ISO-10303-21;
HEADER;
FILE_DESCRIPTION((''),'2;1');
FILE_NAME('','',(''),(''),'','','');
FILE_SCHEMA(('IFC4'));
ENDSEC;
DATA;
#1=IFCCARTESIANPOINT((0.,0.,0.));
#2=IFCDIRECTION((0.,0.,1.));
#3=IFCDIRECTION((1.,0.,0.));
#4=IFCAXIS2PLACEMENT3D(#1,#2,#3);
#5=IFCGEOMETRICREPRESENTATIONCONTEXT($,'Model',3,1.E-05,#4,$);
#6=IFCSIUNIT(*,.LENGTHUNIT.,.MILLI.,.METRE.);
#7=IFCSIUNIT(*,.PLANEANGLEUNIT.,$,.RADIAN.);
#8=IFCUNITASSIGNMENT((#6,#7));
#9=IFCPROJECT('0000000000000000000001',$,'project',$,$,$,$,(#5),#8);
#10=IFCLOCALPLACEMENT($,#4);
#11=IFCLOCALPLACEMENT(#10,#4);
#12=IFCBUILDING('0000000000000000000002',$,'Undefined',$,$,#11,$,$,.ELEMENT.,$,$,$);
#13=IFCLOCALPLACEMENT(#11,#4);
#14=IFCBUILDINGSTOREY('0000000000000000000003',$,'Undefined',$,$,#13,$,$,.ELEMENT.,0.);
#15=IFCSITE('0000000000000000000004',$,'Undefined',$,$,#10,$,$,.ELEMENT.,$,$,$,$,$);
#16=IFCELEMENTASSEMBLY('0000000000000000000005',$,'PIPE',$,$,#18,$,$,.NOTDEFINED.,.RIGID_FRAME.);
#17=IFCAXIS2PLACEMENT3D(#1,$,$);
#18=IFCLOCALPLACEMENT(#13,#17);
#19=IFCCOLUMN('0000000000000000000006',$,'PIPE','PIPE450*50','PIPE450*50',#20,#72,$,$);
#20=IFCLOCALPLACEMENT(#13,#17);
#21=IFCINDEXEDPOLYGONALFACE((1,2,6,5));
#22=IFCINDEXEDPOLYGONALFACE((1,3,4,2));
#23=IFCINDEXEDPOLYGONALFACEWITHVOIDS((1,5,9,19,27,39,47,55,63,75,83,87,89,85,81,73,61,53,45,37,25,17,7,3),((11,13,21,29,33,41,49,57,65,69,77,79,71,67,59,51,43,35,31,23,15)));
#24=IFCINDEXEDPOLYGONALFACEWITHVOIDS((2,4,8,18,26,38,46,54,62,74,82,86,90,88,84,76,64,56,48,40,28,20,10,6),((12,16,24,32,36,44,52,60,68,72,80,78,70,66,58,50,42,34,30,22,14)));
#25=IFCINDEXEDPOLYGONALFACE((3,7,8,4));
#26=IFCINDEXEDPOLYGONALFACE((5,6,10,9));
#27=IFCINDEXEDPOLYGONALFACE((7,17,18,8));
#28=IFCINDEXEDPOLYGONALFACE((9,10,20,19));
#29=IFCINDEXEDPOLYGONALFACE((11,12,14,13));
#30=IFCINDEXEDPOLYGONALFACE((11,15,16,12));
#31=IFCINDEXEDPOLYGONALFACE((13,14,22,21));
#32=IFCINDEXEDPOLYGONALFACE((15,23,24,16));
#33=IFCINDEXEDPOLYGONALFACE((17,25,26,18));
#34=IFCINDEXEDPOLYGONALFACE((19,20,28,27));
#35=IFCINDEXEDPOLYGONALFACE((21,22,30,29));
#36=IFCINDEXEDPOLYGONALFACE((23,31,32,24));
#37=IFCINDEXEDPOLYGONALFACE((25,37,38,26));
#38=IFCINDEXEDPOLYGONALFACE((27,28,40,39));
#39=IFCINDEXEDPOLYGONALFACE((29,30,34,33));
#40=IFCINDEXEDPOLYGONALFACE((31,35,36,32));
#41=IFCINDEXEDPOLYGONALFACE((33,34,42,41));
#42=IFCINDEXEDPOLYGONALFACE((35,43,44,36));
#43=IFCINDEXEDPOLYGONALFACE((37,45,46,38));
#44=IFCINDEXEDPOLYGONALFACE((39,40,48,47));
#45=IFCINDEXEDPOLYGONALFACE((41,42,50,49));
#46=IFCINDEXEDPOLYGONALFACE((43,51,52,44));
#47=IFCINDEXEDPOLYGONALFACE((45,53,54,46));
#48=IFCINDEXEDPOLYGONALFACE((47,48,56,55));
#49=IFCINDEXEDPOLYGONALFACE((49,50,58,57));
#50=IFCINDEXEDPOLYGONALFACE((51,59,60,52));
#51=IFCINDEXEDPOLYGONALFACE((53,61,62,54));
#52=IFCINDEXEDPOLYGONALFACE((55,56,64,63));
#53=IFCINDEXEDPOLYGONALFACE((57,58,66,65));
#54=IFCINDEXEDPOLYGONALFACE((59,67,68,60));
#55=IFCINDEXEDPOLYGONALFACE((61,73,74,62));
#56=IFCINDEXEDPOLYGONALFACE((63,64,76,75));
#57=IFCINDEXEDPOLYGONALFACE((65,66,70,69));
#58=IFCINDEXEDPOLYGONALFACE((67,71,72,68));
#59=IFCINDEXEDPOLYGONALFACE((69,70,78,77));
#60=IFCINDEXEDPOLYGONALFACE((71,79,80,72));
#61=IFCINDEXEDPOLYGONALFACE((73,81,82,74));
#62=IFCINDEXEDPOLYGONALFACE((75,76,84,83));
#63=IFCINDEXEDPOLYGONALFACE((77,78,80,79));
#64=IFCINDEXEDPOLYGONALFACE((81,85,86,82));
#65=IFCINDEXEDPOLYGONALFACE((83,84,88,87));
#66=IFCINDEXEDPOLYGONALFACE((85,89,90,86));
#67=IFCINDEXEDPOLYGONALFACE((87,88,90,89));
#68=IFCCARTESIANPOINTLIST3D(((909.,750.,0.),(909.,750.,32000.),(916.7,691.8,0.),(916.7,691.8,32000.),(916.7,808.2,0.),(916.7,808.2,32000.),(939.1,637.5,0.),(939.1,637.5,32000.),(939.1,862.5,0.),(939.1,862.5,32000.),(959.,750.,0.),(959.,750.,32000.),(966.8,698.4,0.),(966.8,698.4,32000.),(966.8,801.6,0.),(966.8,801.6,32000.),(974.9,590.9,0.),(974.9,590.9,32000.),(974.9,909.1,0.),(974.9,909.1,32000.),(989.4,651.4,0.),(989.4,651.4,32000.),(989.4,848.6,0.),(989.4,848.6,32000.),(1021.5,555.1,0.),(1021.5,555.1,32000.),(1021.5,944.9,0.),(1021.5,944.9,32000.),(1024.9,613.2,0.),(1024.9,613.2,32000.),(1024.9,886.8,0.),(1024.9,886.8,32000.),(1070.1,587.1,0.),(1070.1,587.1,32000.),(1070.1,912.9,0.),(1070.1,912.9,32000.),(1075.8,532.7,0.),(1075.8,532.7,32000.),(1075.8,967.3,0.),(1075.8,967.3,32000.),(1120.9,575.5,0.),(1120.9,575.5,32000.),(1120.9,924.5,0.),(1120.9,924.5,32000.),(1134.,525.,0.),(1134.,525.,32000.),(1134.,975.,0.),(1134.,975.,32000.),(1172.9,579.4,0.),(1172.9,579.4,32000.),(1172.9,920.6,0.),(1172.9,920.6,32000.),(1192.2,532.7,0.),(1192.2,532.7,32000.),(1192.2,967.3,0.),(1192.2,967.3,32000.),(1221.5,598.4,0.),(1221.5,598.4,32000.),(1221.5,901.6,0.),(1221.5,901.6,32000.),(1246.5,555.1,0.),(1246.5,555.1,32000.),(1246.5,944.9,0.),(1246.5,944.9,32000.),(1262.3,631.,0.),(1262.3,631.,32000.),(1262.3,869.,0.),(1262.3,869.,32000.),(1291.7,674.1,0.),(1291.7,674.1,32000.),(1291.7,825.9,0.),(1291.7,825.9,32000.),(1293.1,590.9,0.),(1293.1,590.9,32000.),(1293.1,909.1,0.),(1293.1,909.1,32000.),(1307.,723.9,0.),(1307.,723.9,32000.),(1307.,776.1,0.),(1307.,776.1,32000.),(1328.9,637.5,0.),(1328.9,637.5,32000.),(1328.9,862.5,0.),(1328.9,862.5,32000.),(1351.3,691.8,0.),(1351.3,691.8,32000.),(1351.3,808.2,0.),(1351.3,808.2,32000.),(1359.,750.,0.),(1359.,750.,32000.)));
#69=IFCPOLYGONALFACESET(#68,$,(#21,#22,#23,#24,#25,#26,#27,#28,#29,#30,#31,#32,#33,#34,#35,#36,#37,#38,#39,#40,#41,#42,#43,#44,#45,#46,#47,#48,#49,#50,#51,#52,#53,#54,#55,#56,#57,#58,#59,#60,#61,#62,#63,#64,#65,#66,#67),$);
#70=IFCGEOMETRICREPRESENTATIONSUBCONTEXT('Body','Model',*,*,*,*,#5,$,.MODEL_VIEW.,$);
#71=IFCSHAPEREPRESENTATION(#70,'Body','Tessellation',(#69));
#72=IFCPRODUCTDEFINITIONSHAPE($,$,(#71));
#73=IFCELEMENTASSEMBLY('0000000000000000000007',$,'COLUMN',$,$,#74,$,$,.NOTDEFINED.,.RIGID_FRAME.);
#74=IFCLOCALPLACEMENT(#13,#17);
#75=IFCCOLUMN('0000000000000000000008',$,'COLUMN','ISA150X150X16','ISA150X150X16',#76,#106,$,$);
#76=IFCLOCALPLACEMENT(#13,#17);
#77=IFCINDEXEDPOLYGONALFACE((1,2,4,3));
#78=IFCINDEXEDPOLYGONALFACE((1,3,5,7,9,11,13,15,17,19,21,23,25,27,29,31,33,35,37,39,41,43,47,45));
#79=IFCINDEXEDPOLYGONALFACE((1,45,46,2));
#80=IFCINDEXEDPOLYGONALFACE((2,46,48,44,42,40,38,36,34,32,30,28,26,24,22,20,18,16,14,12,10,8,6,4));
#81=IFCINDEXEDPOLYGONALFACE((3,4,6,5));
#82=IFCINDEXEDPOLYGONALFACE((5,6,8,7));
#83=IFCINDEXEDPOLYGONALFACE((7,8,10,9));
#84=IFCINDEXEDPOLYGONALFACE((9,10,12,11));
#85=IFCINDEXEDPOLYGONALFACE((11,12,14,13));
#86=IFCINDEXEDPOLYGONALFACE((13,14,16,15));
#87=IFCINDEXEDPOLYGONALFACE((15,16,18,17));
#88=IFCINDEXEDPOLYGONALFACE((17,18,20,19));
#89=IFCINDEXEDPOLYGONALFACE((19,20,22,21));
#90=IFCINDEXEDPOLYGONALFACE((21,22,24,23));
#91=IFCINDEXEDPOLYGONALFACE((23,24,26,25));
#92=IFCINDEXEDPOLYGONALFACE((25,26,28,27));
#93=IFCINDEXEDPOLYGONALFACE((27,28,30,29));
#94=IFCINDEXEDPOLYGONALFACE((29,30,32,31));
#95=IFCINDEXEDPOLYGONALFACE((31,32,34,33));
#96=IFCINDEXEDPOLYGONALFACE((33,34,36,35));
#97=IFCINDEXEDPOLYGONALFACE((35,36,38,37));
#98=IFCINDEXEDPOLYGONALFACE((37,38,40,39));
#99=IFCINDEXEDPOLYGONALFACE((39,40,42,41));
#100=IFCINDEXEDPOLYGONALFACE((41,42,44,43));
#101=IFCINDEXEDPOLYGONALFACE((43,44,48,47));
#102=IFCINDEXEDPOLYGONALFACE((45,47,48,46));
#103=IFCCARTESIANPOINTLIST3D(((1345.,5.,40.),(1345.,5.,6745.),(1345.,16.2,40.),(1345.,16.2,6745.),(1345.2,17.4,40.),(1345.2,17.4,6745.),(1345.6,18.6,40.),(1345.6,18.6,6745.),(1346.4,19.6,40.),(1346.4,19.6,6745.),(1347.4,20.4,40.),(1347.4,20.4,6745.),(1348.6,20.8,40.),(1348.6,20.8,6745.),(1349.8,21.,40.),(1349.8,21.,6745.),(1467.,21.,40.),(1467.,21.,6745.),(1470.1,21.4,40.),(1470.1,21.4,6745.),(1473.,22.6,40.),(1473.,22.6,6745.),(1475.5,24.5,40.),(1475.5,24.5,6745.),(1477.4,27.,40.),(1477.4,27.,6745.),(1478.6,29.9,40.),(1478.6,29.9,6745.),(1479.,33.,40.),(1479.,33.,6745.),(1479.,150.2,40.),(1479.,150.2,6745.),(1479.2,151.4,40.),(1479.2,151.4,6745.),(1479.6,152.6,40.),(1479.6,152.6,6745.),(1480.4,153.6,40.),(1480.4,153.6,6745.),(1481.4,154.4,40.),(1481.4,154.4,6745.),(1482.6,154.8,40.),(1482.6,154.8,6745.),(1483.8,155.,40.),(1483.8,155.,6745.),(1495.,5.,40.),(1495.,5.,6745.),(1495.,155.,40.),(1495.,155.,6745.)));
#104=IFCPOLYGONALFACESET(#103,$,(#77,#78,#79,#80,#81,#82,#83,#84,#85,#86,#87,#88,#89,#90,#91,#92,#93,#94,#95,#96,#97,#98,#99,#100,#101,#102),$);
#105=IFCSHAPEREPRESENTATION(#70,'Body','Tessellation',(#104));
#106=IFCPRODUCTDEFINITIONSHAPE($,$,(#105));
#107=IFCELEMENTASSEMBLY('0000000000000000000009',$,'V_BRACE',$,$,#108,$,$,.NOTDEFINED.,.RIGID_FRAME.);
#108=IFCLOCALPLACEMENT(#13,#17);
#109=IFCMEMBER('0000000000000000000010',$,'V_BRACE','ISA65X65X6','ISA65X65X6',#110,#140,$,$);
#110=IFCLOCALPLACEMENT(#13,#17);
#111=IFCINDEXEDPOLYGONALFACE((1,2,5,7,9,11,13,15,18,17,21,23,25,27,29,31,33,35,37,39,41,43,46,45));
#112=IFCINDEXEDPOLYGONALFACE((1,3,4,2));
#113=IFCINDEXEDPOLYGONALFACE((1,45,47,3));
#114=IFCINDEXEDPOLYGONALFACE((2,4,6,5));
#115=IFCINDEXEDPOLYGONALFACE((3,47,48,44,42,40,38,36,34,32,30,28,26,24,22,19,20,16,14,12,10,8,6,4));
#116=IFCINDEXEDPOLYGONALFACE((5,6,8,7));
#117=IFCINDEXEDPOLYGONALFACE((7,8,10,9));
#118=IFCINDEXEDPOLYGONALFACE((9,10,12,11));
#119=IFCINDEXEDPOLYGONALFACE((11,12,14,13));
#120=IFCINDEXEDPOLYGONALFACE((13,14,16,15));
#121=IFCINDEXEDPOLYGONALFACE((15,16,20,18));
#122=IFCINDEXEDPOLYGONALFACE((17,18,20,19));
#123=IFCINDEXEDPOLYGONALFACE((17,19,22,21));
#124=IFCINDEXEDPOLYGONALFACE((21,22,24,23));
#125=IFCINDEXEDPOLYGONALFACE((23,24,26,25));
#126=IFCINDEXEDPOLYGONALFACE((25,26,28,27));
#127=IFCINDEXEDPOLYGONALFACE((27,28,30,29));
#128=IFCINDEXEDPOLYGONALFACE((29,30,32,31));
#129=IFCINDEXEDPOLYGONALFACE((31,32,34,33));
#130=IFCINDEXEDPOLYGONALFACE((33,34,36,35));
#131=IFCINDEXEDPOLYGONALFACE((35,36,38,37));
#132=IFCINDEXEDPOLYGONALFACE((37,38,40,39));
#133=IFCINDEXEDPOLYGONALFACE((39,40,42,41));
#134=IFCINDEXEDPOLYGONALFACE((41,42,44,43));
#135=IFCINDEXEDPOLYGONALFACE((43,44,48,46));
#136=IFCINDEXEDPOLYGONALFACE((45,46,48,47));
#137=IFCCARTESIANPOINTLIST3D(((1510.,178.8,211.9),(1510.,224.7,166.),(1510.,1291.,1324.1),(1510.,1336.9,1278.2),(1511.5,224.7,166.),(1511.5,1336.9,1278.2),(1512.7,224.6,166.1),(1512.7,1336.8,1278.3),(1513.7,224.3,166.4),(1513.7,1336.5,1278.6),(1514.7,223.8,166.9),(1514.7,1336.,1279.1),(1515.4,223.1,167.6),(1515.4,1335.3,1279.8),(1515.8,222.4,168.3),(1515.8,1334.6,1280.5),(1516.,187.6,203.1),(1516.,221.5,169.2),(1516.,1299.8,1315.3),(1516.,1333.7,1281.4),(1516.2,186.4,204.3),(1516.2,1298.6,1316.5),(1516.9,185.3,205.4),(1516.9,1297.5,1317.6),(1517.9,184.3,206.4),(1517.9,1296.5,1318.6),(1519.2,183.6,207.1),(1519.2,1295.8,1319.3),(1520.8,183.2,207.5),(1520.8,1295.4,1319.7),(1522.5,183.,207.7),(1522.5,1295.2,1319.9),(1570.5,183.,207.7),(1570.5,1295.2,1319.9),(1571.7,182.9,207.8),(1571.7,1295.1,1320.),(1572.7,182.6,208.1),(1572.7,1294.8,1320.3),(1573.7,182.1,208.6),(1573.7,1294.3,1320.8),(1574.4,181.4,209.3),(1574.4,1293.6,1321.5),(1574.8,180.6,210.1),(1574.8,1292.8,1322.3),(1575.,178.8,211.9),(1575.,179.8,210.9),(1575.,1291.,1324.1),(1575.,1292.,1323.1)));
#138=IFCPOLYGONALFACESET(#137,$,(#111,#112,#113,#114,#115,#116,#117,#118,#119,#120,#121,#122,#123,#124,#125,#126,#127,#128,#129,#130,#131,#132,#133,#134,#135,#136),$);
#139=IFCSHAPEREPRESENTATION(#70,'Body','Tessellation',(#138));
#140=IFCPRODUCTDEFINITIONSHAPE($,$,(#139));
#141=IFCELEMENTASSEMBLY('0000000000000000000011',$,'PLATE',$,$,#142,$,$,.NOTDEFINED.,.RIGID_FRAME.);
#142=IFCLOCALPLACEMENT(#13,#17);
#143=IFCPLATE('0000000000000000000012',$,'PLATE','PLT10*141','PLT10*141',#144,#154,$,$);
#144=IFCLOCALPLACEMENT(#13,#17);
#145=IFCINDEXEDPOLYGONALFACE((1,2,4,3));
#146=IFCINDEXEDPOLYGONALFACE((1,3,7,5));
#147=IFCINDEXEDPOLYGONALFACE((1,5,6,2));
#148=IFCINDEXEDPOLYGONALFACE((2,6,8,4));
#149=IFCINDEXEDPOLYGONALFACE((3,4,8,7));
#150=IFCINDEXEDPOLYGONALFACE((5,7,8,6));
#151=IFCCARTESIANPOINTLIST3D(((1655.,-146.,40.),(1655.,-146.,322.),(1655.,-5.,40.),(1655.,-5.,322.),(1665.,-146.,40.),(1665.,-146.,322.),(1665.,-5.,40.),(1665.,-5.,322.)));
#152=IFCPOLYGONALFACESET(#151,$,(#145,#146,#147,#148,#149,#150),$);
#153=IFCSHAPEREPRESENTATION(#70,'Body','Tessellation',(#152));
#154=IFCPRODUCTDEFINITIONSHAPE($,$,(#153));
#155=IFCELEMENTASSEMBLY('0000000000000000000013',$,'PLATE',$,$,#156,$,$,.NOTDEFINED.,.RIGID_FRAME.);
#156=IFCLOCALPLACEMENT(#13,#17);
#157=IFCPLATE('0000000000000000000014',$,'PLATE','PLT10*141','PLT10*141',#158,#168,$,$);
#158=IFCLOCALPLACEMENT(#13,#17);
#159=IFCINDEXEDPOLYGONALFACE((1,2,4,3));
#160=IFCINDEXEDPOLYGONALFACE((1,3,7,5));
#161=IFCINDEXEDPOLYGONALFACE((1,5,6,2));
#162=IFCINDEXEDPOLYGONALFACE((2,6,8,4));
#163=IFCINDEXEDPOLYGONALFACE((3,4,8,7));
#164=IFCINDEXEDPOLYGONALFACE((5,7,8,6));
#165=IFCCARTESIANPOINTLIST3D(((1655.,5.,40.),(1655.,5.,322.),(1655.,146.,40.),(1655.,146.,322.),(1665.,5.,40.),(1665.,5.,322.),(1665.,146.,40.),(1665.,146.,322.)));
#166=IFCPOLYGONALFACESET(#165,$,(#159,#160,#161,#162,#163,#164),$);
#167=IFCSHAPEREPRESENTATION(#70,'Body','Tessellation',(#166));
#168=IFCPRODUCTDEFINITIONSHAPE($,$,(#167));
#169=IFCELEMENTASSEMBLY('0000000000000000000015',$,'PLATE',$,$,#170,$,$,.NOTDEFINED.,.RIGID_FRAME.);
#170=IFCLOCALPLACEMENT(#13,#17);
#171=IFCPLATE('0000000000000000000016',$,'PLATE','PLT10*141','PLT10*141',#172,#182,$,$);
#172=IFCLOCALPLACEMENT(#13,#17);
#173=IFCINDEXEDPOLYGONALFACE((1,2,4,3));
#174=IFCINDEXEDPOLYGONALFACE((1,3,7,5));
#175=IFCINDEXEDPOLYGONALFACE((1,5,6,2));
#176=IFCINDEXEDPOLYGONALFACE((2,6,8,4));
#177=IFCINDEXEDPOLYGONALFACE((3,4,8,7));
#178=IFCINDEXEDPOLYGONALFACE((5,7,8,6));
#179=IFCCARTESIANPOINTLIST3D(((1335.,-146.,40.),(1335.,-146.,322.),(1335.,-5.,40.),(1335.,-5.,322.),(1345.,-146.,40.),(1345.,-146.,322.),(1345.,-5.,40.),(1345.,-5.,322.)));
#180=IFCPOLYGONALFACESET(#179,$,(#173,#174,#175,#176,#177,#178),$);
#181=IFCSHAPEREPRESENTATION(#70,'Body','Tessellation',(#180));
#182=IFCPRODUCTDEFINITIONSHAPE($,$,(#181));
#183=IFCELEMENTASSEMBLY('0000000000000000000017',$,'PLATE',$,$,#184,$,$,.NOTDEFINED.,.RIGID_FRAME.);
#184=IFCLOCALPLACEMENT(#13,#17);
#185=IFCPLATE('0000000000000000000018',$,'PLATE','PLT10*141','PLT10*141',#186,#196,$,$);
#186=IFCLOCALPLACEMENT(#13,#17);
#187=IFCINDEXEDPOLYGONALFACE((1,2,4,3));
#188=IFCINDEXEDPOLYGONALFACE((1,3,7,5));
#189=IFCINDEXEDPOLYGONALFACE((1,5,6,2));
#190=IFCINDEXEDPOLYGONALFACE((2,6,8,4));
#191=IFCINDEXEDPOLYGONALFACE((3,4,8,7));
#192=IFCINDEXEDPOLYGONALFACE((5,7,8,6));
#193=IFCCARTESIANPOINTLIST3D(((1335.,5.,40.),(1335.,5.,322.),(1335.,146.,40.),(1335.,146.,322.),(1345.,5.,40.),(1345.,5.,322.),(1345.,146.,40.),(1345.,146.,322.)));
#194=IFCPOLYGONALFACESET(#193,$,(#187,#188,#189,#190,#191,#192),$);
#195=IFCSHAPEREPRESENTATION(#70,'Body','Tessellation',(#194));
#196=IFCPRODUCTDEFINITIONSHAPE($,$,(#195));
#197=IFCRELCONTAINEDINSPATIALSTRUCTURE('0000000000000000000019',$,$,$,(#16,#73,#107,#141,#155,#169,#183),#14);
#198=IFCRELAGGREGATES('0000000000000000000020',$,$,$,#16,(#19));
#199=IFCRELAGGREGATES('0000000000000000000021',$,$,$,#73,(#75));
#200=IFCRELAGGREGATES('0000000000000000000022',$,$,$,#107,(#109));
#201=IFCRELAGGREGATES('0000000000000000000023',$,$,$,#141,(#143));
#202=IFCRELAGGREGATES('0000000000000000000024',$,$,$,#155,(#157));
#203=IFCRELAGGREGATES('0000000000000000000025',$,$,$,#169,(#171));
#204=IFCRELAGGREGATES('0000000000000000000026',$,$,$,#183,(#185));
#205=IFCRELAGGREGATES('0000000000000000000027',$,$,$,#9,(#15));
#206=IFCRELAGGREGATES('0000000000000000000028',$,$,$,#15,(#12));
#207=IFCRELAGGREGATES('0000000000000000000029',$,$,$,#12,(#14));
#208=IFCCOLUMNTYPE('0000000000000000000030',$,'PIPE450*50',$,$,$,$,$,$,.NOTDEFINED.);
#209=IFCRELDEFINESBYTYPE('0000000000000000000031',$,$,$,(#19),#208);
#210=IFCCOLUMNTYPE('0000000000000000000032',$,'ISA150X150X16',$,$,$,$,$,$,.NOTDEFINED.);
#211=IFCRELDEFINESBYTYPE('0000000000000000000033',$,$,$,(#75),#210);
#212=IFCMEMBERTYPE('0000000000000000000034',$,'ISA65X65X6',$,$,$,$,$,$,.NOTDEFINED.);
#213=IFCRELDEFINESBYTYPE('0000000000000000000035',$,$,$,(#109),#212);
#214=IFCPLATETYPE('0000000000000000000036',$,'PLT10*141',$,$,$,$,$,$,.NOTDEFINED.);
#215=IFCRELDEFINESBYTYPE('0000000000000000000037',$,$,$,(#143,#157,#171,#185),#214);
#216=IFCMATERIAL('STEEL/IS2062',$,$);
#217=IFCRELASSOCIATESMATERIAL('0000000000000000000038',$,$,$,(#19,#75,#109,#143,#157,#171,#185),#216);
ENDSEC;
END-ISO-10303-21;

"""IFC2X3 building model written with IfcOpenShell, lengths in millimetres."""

from ifc_helpers import new_model, si_unit, frame, origin_with_axes, origin_2d_with_axis, place, context, subcontext, project, spatial, polyline, hollow_circle, l_section, outline, extrude, clip, halfspace, material, type_object, element, aggregate, save


model = new_model("IFC2X3")

# Units and contexts
model_context = context("Model", 3, precision=1e-05, world=origin_with_axes())
body_context = subcontext(model_context, "Body", "Model", "MODEL_VIEW")
ifc_project = project(units=[si_unit("LENGTHUNIT", "METRE", prefix="MILLI"), si_unit("PLANEANGLEUNIT", "RADIAN")], contexts=[model_context])

# Site, building, storey
site_placement = place(None, origin_with_axes())
site = spatial("IfcSite", under=ifc_project, at=site_placement, Name="Undefined", CompositionType="ELEMENT")
building_placement = place(site_placement, origin_with_axes())
building = spatial("IfcBuilding", under=site, at=building_placement, Name="Undefined", CompositionType="ELEMENT")
storey_placement = place(building_placement, origin_with_axes())
storey = spatial("IfcBuildingStorey", under=building, at=storey_placement, Name="Undefined", CompositionType="ELEMENT", Elevation=0.0)

# Element assemblies, columns
assembly_1_placement = place(storey_placement, origin_with_axes())
assembly_1 = element("IfcElementAssembly", 1, at=assembly_1_placement, inside=storey, Name="PIPE", AssemblyPlace="NOTDEFINED", PredefinedType="RIGID_FRAME")
ifc_material_1 = material(Name="STEEL/IS2062")
column_type_1 = type_object("IfcColumnType", Name="PIPE450*50", PredefinedType="NOTDEFINED")
column_1_placement = place(assembly_1_placement, frame((1134.0, 750.0, 0.0), z_axis=(0.0, 0.0, 1.0), x_axis=(0.0, 1.0, 0.0)))
column_1 = element("IfcColumn", 2, at=column_1_placement, type_object=column_type_1, material=ifc_material_1, Name="PIPE", Description="PIPE450*50", ObjectType="PIPE450*50", context=body_context, shape_type="SweptSolid", body=[
    extrude(hollow_circle(Radius=225.0, WallThickness=50.0, at=origin_2d_with_axis()), frame((0.0, 0.0, 32000.0), z_axis=(0.0, 0.0, -1.0), x_axis=(0.0, 1.0, 0.0)), (0.0, 0.0, 1.0), 32000.0),
])
aggregate(assembly_1, [column_1])
assembly_2_placement = place(storey_placement, origin_with_axes())
assembly_2 = element("IfcElementAssembly", 3, at=assembly_2_placement, inside=storey, Name="COLUMN", AssemblyPlace="NOTDEFINED", PredefinedType="RIGID_FRAME")
column_type_2 = type_object("IfcColumnType", Name="ISA150X150X16", PredefinedType="NOTDEFINED")
column_2_placement = place(assembly_2_placement, frame((1420.0, 80.0, 40.0), z_axis=(0.0, 0.0, 1.0), x_axis=(0.0, 1.0, 0.0)))
column_2 = element("IfcColumn", 4, at=column_2_placement, type_object=column_type_2, material=ifc_material_1, Name="COLUMN", Description="ISA150X150X16", ObjectType="ISA150X150X16", context=body_context, shape_type="SweptSolid", body=[
    extrude(l_section(Depth=150.0, Width=150.0, Thickness=16.0, FilletRadius=12.0, EdgeRadius=4.8, at=origin_2d_with_axis()), frame((0.0, 0.0, 6705.0), z_axis=(0.0, 0.0, -1.0), x_axis=(0.0, 1.0, 0.0)), (0.0, 0.0, 1.0), 6705.0),
])
aggregate(assembly_2, [column_2])

# Element assembly, member
assembly_3_placement = place(storey_placement, origin_with_axes())
assembly_3 = element("IfcElementAssembly", 5, at=assembly_3_placement, inside=storey, Name="V_BRACE", AssemblyPlace="NOTDEFINED", PredefinedType="RIGID_FRAME")
member_type = type_object("IfcMemberType", Name="ISA65X65X6", PredefinedType="NOTDEFINED")
member_placement = place(assembly_3_placement, frame((1542.5, 201.7, 189.0), z_axis=(1.0, 0.0, 0.0), x_axis=(0.0, 0.707107, 0.707107)))
member = element("IfcMember", 6, at=member_placement, type_object=member_type, material=ifc_material_1, Name="V_BRACE", Description="ISA65X65X6", ObjectType="ISA65X65X6", context=body_context, shape_type="Clipping", body=[
    clip(extrude(l_section(Depth=65.0, Width=65.0, Thickness=6.0, FilletRadius=6.5, EdgeRadius=4.5, at=origin_2d_with_axis()), frame((1839.6, 0.0, 0.0), z_axis=(-1.0, 0.0, 0.0), x_axis=(0.0, -1.0, 0.0)), (0.0, 0.0, 1.0), 1839.6), halfspace(frame((1572.9, 0.0, -42.5), z_axis=(-1.0, 0.0, 0.0), x_axis=(0.0, 1.0, 0.0)), True)),
])
aggregate(assembly_3, [member])

# Element assemblies, plates
assembly_4_placement = place(storey_placement, origin_with_axes())
assembly_4 = element("IfcElementAssembly", 7, at=assembly_4_placement, inside=storey, Name="PLATE", AssemblyPlace="NOTDEFINED", PredefinedType="RIGID_FRAME")
plate_type_1 = type_object("IfcPlateType", Name="PLT10*141", PredefinedType="NOTDEFINED")
plate_1_placement = place(assembly_4_placement, frame((1660.0, -146.0, 322.0), z_axis=(1.0, 0.0, 0.0), x_axis=(0.0, 0.0, -1.0)))
plate_1 = element("IfcPlate", 8, at=plate_1_placement, type_object=plate_type_1, material=ifc_material_1, Name="PLATE", Description="PLT10*141", ObjectType="PLT10*141", context=body_context, shape_type="SweptSolid", body=[
    extrude(outline(polyline([(0.0, 0.0), (282.0, 0.0), (282.0, 141.0), (0.0, 141.0), (0.0, 0.0)])), frame((0.0, 0.0, -5.0), z_axis=(0.0, 0.0, 1.0), x_axis=(1.0, 0.0, 0.0)), (0.0, 0.0, 1.0), 10.0),
])
aggregate(assembly_4, [plate_1])
assembly_5_placement = place(storey_placement, origin_with_axes())
assembly_5 = element("IfcElementAssembly", 9, at=assembly_5_placement, inside=storey, Name="PLATE", AssemblyPlace="NOTDEFINED", PredefinedType="RIGID_FRAME")
plate_2_placement = place(assembly_5_placement, frame((1660.0, 146.0, 322.0), z_axis=(-1.0, 0.0, 0.0), x_axis=(0.0, 0.0, -1.0)))
plate_2 = element("IfcPlate", 10, at=plate_2_placement, type_object=plate_type_1, material=ifc_material_1, Name="PLATE", Description="PLT10*141", ObjectType="PLT10*141", context=body_context, shape_type="SweptSolid", body=[
    extrude(outline(polyline([(0.0, 0.0), (282.0, 0.0), (282.0, 141.0), (0.0, 141.0), (0.0, 0.0)])), frame((0.0, 0.0, -5.0), z_axis=(0.0, 0.0, 1.0), x_axis=(1.0, 0.0, 0.0)), (0.0, 0.0, 1.0), 10.0),
])
aggregate(assembly_5, [plate_2])
assembly_6_placement = place(storey_placement, origin_with_axes())
assembly_6 = element("IfcElementAssembly", 11, at=assembly_6_placement, inside=storey, Name="PLATE", AssemblyPlace="NOTDEFINED", PredefinedType="RIGID_FRAME")
plate_3_placement = place(assembly_6_placement, frame((1340.0, -146.0, 322.0), z_axis=(1.0, 0.0, 0.0), x_axis=(0.0, 0.0, -1.0)))
plate_3 = element("IfcPlate", 12, at=plate_3_placement, type_object=plate_type_1, material=ifc_material_1, Name="PLATE", Description="PLT10*141", ObjectType="PLT10*141", context=body_context, shape_type="SweptSolid", body=[
    extrude(outline(polyline([(0.0, 0.0), (282.0, 0.0), (282.0, 141.0), (0.0, 141.0), (0.0, 0.0)])), frame((0.0, 0.0, -5.0), z_axis=(0.0, 0.0, 1.0), x_axis=(1.0, 0.0, 0.0)), (0.0, 0.0, 1.0), 10.0),
])
aggregate(assembly_6, [plate_3])
assembly_7_placement = place(storey_placement, origin_with_axes())
assembly_7 = element("IfcElementAssembly", 13, at=assembly_7_placement, inside=storey, Name="PLATE", AssemblyPlace="NOTDEFINED", PredefinedType="RIGID_FRAME")
plate_4_placement = place(assembly_7_placement, frame((1340.0, 146.0, 322.0), z_axis=(-1.0, 0.0, 0.0), x_axis=(0.0, 0.0, -1.0)))
plate_4 = element("IfcPlate", 14, at=plate_4_placement, type_object=plate_type_1, material=ifc_material_1, Name="PLATE", Description="PLT10*141", ObjectType="PLT10*141", context=body_context, shape_type="SweptSolid", body=[
    extrude(outline(polyline([(0.0, 0.0), (282.0, 0.0), (282.0, 141.0), (0.0, 141.0), (0.0, 0.0)])), frame((0.0, 0.0, -5.0), z_axis=(0.0, 0.0, 1.0), x_axis=(1.0, 0.0, 0.0)), (0.0, 0.0, 1.0), 10.0),
])
aggregate(assembly_7, [plate_4])

save(model, "model.ifc")
